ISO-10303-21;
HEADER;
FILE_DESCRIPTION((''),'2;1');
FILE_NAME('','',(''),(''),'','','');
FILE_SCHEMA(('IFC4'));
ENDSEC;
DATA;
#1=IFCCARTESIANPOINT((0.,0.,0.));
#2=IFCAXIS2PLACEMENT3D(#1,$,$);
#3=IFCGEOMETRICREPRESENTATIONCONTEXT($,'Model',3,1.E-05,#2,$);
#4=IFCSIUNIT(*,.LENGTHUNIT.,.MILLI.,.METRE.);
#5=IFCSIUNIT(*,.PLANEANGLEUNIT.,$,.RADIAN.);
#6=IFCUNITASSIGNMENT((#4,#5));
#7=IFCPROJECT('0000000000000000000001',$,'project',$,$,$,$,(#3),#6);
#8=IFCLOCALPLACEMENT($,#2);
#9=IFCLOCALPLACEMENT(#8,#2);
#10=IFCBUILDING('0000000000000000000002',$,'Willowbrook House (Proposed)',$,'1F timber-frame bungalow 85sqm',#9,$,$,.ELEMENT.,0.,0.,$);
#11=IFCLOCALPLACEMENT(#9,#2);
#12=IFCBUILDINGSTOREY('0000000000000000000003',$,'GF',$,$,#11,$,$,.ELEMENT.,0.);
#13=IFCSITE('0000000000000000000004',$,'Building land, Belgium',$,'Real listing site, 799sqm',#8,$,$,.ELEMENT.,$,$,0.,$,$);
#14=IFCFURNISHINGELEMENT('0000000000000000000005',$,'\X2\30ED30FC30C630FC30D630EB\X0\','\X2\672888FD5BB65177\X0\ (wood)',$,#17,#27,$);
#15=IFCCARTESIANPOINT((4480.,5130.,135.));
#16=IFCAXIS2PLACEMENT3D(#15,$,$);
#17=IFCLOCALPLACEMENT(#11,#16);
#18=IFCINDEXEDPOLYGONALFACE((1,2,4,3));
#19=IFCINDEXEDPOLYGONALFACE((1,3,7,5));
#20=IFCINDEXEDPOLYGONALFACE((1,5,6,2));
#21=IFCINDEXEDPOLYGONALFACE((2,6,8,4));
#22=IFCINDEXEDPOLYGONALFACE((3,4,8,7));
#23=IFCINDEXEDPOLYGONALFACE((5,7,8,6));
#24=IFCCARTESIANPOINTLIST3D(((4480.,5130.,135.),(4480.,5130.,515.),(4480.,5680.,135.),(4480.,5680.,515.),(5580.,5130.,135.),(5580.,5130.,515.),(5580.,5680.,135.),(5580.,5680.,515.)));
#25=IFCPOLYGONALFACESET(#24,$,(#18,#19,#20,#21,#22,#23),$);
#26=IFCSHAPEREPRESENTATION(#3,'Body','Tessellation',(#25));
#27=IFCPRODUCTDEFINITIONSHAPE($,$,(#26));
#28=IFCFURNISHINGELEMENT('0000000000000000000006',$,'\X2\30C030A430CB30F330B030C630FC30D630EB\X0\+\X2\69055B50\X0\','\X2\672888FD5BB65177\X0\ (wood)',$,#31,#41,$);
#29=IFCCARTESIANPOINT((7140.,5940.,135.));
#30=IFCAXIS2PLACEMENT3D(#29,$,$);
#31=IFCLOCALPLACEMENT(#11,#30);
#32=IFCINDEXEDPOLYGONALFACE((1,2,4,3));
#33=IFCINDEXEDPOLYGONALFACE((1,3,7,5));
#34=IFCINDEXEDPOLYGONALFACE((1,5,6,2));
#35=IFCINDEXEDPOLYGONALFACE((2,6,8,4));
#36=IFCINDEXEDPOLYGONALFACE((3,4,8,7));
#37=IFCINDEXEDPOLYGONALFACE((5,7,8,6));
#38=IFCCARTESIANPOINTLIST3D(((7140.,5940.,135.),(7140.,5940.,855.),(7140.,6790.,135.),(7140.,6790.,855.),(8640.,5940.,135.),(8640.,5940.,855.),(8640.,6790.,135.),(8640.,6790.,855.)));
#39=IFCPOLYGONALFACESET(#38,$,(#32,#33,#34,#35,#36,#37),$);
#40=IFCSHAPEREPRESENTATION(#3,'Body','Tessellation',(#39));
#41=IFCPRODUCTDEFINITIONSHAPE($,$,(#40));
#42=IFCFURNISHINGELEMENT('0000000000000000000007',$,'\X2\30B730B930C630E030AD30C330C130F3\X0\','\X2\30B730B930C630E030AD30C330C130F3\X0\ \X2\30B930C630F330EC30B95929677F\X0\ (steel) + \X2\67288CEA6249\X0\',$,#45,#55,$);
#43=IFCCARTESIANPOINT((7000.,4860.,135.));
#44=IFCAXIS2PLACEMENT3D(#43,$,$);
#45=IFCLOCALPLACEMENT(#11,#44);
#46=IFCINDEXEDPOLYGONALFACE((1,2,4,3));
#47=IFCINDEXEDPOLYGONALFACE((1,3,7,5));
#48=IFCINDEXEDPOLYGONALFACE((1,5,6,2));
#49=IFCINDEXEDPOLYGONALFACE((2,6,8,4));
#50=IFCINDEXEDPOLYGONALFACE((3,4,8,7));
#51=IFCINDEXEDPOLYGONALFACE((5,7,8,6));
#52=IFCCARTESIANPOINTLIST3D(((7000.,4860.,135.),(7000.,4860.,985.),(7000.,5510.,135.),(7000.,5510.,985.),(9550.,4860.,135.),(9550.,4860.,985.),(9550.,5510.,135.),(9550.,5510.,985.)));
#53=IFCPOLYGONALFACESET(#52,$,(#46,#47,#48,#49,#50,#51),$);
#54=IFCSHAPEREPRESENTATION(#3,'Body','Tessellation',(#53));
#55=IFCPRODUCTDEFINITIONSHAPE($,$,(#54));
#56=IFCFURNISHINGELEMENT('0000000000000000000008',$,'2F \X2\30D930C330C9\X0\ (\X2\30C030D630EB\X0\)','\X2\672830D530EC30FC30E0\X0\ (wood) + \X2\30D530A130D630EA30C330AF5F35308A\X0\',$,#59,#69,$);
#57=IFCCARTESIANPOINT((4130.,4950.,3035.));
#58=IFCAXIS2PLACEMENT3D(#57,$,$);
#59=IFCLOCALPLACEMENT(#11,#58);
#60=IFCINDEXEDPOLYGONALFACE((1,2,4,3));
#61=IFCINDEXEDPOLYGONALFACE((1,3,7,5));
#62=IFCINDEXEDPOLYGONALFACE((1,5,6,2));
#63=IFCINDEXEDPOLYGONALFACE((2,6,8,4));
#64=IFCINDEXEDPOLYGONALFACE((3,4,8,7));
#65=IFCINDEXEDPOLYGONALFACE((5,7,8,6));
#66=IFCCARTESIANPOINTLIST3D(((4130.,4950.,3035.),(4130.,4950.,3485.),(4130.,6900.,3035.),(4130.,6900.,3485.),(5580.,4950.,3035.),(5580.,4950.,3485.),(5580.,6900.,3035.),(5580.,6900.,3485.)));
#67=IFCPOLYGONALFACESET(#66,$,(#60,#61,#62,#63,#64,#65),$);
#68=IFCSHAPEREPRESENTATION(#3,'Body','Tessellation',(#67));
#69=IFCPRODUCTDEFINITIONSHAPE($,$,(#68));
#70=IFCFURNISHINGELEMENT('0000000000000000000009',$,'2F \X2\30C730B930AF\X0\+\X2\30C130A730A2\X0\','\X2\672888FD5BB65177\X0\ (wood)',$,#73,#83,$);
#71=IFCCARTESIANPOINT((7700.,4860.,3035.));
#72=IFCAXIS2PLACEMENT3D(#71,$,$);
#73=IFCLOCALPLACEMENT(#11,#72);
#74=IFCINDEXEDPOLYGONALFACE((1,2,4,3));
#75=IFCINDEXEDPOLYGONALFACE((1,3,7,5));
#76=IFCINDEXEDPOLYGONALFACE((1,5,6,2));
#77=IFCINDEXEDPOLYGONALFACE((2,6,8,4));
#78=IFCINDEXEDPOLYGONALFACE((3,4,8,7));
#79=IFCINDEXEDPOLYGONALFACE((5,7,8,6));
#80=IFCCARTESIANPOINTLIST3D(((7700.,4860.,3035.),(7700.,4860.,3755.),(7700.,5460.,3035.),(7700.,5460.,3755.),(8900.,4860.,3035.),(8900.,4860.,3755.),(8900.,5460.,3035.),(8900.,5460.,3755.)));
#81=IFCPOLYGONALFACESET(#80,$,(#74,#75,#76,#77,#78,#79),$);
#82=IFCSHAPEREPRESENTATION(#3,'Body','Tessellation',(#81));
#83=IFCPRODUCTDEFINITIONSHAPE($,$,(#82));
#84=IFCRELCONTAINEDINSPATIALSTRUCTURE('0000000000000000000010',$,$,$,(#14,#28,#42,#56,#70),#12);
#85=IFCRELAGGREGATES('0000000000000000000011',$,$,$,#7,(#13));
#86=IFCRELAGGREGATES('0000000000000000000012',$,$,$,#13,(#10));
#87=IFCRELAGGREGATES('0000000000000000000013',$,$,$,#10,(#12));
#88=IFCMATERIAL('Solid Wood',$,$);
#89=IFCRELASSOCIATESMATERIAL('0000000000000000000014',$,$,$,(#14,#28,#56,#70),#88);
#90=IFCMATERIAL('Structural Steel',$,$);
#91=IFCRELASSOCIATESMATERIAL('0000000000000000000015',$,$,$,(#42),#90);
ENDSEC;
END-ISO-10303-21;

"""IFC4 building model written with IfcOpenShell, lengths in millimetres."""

from ifc_helpers import new_model, si_unit, frame, frame_2d, origin, place, context, project, spatial, rectangle, extrude, material, element, save


model = new_model("IFC4")

# Units and contexts
model_context = context("Model", 3, precision=1e-05, world=origin())
ifc_project = project(units=[si_unit("LENGTHUNIT", "METRE", prefix="MILLI"), si_unit("PLANEANGLEUNIT", "RADIAN")], contexts=[model_context])

# Site, building, storey
site_placement = place(None, origin())
site = spatial("IfcSite", under=ifc_project, at=site_placement, Name="Building land, Belgium", ObjectType="Real listing site, 799sqm", CompositionType="ELEMENT", RefElevation=0.0)
building_placement = place(site_placement, origin())
building = spatial("IfcBuilding", under=site, at=building_placement, Name="Willowbrook House (Proposed)", ObjectType="1F timber-frame bungalow 85sqm", CompositionType="ELEMENT", ElevationOfRefHeight=0.0, ElevationOfTerrain=0.0)
storey_placement = place(building_placement, origin())
storey = spatial("IfcBuildingStorey", under=building, at=storey_placement, Name="GF", CompositionType="ELEMENT", Elevation=0.0)

# Shared definitions
ifc_material_1 = material(Name="Solid Wood")

# Shared definitions
ifc_material_2 = material(Name="Structural Steel")

# Furnishing elements
furnishing_1_placement = place(storey_placement, frame((4480.0, 5130.0, 135.0)))
element("IfcFurnishingElement", 1, at=furnishing_1_placement, inside=storey, material=ifc_material_1, Name="ローテーブル", Description="木製家具 (wood)", context=model_context, shape_type="SweptSolid", body=[
    extrude(rectangle(XDim=1100.0, YDim=550.0, at=frame_2d((550.0, 275.0))), frame((4480.0, 5130.0, 135.0)), (0.0, 0.0, 1.0), 380.0),
])
furnishing_2_placement = place(storey_placement, frame((7140.0, 5940.0, 135.0)))
element("IfcFurnishingElement", 2, at=furnishing_2_placement, inside=storey, material=ifc_material_1, Name="ダイニングテーブル+椅子", Description="木製家具 (wood)", context=model_context, shape_type="SweptSolid", body=[
    extrude(rectangle(XDim=1500.0, YDim=850.0, at=frame_2d((750.0, 425.0))), frame((7140.0, 5940.0, 135.0)), (0.0, 0.0, 1.0), 720.0),
])
furnishing_3_placement = place(storey_placement, frame((7000.0, 4860.0, 135.0)))
element("IfcFurnishingElement", 3, at=furnishing_3_placement, inside=storey, material=ifc_material_2, Name="システムキッチン", Description="システムキッチン ステンレス天板 (steel) + 木質扉", context=model_context, shape_type="SweptSolid", body=[
    extrude(rectangle(XDim=2550.0, YDim=650.0, at=frame_2d((1275.0, 325.0))), frame((7000.0, 4860.0, 135.0)), (0.0, 0.0, 1.0), 850.0),
])
furnishing_4_placement = place(storey_placement, frame((4130.0, 4950.0, 3035.0)))
element("IfcFurnishingElement", 4, at=furnishing_4_placement, inside=storey, material=ifc_material_1, Name="2F ベッド (ダブル)", Description="木フレーム (wood) + ファブリック張り", context=model_context, shape_type="SweptSolid", body=[
    extrude(rectangle(XDim=1450.0, YDim=1950.0, at=frame_2d((725.0, 975.0))), frame((4130.0, 4950.0, 3035.0)), (0.0, 0.0, 1.0), 450.0),
])
furnishing_5_placement = place(storey_placement, frame((7700.0, 4860.0, 3035.0)))
element("IfcFurnishingElement", 5, at=furnishing_5_placement, inside=storey, material=ifc_material_1, Name="2F デスク+チェア", Description="木製家具 (wood)", context=model_context, shape_type="SweptSolid", body=[
    extrude(rectangle(XDim=1200.0, YDim=600.0, at=frame_2d((600.0, 300.0))), frame((7700.0, 4860.0, 3035.0)), (0.0, 0.0, 1.0), 720.0),
])

save(model, "model.ifc")
